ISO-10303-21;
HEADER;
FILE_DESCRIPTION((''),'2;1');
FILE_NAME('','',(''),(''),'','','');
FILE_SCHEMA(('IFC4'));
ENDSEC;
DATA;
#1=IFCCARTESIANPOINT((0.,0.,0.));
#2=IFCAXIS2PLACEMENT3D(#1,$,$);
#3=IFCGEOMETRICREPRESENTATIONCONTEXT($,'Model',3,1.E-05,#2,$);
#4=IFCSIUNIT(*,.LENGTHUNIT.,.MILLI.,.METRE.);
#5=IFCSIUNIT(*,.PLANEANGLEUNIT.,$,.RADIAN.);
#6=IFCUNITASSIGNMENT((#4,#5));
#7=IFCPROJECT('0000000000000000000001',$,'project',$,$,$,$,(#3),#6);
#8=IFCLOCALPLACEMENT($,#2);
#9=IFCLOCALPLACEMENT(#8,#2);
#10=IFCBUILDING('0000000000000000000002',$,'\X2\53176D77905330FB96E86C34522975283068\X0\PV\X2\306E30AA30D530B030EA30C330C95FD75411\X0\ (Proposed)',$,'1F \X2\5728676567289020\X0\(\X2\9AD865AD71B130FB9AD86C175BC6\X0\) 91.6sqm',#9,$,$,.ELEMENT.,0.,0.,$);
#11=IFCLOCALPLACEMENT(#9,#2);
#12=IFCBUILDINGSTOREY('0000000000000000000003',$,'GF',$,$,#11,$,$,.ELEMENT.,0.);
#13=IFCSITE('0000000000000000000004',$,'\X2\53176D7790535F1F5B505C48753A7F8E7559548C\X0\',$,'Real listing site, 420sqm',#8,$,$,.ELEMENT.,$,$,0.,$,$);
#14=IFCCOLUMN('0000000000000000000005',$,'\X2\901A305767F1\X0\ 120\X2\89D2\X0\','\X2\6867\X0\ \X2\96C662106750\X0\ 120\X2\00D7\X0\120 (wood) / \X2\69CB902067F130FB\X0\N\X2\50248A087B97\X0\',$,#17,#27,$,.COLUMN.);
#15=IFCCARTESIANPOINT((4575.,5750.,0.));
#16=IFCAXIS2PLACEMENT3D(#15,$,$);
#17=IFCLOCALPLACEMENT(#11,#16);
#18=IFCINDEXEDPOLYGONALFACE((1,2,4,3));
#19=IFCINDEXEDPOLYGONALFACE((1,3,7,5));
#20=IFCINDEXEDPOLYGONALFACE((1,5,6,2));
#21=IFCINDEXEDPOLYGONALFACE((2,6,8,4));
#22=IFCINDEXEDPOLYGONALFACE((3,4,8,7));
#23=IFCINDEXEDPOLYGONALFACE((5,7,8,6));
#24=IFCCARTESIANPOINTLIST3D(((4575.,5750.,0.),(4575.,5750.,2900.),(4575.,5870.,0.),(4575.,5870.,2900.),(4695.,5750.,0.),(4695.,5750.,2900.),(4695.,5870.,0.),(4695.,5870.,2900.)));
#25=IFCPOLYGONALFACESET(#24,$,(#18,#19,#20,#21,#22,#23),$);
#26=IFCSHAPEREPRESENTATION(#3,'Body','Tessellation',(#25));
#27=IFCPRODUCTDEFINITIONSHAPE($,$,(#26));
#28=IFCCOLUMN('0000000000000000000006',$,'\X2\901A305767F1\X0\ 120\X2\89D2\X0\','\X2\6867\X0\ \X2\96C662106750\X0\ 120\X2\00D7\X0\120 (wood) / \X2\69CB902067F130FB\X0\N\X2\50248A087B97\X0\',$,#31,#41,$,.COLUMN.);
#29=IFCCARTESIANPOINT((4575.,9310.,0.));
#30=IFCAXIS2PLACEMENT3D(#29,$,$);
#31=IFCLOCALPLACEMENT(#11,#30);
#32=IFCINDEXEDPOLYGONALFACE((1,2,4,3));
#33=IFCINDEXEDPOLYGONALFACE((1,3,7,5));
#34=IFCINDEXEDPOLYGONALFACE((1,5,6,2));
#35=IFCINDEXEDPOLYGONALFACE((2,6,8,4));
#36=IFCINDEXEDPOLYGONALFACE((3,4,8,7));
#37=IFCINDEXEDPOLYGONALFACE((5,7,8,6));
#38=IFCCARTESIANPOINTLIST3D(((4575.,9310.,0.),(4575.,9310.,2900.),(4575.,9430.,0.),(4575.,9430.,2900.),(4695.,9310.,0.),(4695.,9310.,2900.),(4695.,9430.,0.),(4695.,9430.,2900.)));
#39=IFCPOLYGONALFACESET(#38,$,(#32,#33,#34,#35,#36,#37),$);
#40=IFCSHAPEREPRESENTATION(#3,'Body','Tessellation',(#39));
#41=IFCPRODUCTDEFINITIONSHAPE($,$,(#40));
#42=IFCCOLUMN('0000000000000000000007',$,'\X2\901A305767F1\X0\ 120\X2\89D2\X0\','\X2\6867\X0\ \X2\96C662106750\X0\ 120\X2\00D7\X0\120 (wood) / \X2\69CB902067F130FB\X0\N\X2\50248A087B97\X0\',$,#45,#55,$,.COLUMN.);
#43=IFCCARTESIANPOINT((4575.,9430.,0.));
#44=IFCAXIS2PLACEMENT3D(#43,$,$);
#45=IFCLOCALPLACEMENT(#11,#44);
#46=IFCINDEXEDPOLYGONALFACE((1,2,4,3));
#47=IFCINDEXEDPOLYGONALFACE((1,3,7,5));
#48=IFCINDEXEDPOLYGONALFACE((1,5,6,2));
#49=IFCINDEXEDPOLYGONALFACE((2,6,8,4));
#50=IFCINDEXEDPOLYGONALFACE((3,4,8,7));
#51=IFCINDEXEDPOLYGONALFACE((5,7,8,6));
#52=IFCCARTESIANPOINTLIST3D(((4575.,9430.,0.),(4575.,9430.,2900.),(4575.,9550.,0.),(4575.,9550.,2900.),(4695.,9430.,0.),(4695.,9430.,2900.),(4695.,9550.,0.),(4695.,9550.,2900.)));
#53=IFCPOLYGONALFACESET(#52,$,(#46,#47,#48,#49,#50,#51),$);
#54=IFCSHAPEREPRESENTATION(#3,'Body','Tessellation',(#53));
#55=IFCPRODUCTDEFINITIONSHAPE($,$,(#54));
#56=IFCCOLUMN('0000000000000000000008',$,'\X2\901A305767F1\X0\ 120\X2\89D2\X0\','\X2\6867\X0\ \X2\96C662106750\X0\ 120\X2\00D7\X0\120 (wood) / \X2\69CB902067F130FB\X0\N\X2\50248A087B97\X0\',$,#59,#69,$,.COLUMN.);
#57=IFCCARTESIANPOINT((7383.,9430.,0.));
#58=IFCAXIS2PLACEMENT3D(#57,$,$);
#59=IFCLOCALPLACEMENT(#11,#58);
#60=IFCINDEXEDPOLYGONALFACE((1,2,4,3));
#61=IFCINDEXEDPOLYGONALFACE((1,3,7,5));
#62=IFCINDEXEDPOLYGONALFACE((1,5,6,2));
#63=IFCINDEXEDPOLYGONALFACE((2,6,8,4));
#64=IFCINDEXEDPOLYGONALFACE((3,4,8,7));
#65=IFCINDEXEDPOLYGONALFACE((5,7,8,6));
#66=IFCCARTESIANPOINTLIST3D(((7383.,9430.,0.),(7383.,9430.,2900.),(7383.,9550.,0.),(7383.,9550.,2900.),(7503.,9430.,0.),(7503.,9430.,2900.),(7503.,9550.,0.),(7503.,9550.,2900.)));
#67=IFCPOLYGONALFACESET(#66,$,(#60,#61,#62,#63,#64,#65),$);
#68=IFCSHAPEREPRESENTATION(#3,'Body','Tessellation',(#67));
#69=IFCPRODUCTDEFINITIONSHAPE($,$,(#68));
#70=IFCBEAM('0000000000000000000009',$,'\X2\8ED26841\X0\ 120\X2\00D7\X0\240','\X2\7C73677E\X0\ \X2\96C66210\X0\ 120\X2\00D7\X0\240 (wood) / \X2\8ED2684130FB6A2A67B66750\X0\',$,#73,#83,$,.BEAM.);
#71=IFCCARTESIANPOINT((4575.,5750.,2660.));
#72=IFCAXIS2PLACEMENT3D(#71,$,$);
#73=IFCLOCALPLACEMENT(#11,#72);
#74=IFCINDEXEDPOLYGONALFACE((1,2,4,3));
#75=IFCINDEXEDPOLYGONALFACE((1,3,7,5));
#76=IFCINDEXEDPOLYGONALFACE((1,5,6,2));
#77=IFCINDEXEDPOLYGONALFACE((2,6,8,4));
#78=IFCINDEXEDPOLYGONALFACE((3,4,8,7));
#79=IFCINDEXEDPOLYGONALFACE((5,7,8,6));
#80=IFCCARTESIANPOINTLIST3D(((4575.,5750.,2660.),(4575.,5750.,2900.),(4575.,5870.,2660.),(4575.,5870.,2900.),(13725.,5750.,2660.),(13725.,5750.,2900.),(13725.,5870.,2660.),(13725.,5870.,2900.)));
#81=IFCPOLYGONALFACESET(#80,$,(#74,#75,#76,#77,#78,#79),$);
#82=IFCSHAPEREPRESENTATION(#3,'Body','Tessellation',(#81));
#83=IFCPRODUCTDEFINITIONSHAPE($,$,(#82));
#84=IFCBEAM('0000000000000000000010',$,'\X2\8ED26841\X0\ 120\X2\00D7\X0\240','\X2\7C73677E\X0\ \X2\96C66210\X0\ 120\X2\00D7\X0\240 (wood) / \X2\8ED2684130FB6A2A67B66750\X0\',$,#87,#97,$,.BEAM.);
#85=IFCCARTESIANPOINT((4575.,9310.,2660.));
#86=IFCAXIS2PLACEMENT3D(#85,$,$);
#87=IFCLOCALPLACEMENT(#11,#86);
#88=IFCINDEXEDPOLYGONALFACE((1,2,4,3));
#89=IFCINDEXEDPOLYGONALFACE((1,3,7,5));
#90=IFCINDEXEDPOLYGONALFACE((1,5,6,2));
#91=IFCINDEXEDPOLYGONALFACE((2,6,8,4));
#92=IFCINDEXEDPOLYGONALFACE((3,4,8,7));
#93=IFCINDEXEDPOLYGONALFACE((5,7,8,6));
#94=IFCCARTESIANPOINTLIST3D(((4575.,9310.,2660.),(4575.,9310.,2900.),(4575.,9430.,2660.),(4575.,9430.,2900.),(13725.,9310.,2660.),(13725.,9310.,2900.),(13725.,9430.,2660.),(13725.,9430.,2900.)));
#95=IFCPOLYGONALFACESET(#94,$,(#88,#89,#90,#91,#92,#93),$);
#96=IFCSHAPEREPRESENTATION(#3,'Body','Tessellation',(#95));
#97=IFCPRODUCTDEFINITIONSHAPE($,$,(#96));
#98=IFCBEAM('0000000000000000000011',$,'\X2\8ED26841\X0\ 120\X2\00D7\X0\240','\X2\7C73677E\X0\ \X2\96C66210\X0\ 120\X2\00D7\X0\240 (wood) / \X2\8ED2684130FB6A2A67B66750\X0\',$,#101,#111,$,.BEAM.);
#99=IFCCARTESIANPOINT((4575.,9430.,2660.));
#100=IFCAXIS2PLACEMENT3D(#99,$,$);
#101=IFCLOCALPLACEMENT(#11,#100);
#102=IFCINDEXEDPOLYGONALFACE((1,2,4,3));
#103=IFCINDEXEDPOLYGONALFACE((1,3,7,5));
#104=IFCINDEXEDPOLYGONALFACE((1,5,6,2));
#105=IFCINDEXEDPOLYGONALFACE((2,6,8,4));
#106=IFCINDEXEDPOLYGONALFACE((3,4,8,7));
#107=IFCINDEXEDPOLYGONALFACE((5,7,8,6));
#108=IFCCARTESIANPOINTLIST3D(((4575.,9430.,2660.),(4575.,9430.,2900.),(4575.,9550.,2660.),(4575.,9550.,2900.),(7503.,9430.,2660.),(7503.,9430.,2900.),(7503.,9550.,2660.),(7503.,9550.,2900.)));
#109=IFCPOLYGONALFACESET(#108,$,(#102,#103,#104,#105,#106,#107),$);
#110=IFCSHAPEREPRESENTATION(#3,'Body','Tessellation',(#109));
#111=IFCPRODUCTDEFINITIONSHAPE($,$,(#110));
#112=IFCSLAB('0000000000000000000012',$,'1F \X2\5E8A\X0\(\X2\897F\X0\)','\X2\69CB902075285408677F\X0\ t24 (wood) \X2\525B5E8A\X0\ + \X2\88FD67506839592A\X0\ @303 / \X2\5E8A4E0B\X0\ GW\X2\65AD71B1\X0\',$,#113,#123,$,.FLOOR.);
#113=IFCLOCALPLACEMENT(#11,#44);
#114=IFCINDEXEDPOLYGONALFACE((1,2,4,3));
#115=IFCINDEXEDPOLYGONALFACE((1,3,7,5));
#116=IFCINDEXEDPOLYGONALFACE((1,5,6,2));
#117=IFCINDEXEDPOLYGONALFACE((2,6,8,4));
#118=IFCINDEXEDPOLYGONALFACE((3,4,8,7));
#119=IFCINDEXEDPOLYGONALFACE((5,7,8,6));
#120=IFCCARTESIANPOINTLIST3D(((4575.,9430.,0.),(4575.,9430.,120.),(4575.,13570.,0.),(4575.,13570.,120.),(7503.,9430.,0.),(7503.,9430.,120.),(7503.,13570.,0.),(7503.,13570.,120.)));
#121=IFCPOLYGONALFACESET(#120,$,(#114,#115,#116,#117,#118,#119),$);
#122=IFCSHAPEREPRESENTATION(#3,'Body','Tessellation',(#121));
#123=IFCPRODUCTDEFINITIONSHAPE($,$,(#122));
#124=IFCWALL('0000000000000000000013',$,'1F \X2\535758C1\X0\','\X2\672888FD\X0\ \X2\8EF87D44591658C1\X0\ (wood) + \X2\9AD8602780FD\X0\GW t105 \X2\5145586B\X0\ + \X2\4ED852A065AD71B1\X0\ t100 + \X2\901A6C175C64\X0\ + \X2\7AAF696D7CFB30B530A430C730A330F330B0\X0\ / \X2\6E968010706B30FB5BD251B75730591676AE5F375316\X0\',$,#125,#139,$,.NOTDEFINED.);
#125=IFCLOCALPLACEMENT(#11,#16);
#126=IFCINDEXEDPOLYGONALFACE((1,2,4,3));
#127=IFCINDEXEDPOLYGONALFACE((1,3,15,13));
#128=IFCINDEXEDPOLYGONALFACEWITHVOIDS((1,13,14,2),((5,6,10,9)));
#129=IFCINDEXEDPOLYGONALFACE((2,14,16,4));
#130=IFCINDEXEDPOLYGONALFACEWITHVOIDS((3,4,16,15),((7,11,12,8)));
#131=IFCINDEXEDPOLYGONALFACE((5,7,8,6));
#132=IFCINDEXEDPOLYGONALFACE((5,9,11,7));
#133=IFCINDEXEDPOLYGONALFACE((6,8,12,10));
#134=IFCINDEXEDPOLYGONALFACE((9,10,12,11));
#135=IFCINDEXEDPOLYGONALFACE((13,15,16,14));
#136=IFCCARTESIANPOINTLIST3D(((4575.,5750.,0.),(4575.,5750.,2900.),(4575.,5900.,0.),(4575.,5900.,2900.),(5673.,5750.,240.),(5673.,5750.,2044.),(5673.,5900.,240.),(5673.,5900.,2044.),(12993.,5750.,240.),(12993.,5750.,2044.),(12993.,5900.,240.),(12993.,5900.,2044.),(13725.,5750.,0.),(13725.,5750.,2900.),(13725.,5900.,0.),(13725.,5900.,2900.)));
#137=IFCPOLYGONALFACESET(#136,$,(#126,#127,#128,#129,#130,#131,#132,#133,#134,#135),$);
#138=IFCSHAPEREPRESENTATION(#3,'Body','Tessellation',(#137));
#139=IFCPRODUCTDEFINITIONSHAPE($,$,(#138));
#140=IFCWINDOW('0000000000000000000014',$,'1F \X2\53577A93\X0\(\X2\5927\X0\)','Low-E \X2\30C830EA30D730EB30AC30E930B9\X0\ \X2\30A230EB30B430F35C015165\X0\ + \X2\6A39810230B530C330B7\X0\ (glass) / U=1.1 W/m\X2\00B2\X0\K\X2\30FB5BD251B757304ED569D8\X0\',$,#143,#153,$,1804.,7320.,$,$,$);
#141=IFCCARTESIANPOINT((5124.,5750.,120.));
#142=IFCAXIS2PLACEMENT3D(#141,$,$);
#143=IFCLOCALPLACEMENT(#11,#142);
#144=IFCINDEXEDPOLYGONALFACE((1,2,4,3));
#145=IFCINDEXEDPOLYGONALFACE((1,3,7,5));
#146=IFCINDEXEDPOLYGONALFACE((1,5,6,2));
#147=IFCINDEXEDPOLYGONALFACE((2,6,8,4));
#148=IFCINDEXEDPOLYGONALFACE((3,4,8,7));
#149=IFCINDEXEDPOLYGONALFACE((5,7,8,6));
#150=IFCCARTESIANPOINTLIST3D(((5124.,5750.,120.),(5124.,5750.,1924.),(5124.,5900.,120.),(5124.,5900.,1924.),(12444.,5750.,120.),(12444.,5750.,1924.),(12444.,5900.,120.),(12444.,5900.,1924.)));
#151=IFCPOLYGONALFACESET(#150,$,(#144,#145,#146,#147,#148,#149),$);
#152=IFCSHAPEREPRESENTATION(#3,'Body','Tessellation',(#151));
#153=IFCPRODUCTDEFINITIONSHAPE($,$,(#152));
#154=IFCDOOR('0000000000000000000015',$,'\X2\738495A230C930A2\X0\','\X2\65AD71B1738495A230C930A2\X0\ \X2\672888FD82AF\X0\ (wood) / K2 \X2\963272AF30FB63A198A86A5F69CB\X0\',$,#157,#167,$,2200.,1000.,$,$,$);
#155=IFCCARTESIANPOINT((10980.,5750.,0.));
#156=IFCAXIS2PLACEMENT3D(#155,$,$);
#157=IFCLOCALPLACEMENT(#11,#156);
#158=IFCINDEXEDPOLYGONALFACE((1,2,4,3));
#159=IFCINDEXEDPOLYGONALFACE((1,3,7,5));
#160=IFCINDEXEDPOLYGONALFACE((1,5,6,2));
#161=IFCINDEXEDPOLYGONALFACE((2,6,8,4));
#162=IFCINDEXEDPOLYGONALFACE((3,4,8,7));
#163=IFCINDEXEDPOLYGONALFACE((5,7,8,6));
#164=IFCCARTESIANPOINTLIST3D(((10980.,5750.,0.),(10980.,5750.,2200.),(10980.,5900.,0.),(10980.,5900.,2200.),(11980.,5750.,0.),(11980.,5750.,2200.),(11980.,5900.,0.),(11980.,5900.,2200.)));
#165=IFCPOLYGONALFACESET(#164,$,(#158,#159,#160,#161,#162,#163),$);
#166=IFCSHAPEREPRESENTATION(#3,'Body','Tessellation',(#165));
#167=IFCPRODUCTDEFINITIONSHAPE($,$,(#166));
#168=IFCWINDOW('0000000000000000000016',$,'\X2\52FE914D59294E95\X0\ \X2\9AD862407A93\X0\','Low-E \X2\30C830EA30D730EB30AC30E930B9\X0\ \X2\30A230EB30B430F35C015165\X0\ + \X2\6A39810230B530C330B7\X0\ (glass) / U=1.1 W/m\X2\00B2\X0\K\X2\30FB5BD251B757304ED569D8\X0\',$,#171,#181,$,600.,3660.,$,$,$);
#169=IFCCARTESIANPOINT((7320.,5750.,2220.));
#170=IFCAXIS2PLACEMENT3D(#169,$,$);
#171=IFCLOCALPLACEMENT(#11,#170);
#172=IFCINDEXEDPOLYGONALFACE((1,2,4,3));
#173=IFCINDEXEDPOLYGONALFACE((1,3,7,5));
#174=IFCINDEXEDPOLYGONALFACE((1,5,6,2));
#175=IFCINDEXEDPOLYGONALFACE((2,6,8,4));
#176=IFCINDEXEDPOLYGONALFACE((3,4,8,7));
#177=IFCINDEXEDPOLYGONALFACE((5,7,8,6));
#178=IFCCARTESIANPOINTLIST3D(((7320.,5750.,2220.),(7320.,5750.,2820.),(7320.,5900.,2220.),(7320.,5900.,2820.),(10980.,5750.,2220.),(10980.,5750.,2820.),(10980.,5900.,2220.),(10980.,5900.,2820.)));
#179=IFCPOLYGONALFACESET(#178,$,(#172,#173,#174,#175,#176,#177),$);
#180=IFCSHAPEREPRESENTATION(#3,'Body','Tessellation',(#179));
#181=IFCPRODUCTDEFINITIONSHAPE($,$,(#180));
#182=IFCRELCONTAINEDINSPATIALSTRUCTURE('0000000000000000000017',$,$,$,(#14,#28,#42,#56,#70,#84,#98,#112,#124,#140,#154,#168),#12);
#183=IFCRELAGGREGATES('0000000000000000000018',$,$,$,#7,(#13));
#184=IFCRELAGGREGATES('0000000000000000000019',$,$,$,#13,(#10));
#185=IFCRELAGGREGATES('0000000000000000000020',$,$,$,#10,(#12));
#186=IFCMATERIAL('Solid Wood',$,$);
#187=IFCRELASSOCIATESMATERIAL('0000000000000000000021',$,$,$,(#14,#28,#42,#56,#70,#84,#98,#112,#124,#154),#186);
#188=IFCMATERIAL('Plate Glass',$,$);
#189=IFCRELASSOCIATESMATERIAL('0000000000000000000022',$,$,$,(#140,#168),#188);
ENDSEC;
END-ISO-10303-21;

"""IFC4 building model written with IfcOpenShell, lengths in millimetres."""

from ifc_helpers import new_model, si_unit, frame, frame_2d, origin, place, context, project, spatial, rectangle, extrude, material, element, fill, save


model = new_model("IFC4")

# Units and contexts
model_context = context("Model", 3, precision=1e-05, world=origin())
ifc_project = project(units=[si_unit("LENGTHUNIT", "METRE", prefix="MILLI"), si_unit("PLANEANGLEUNIT", "RADIAN")], contexts=[model_context])

# Site, building, storey
site_placement = place(None, origin())
site = spatial("IfcSite", under=ifc_project, at=site_placement, Name="北海道弟子屈町美留和", ObjectType="Real listing site, 420sqm", CompositionType="ELEMENT", RefElevation=0.0)
building_placement = place(site_placement, origin())
building = spatial("IfcBuilding", under=site, at=building_placement, Name="北海道・雨水利用とPVのオフグリッド志向 (Proposed)", ObjectType="1F 在来木造(高断熱・高気密) 91.6sqm", CompositionType="ELEMENT", ElevationOfRefHeight=0.0, ElevationOfTerrain=0.0)
storey_placement = place(building_placement, origin())
storey = spatial("IfcBuildingStorey", under=building, at=storey_placement, Name="GF", CompositionType="ELEMENT", Elevation=0.0)

# Columns
ifc_material_1 = material(Name="Solid Wood")
column_1_placement = place(storey_placement, frame((4575.0, 5750.0, 0.0)))
element("IfcColumn", 1, at=column_1_placement, inside=storey, material=ifc_material_1, Name="通し柱 120角", Description="桧 集成材 120×120 (wood) / 構造柱・N値計算", PredefinedType="COLUMN", context=model_context, shape_type="SweptSolid", body=[
    extrude(rectangle(XDim=120.0, YDim=120.0, at=frame_2d((60.0, 60.0))), frame((4575.0, 5750.0, 0.0)), (0.0, 0.0, 1.0), 2900.0),
])
column_2_placement = place(storey_placement, frame((4575.0, 9310.0, 0.0)))
element("IfcColumn", 2, at=column_2_placement, inside=storey, material=ifc_material_1, Name="通し柱 120角", Description="桧 集成材 120×120 (wood) / 構造柱・N値計算", PredefinedType="COLUMN", context=model_context, shape_type="SweptSolid", body=[
    extrude(rectangle(XDim=120.0, YDim=120.0, at=frame_2d((60.0, 60.0))), frame((4575.0, 9310.0, 0.0)), (0.0, 0.0, 1.0), 2900.0),
])
column_3_placement = place(storey_placement, frame((4575.0, 9430.0, 0.0)))
element("IfcColumn", 3, at=column_3_placement, inside=storey, material=ifc_material_1, Name="通し柱 120角", Description="桧 集成材 120×120 (wood) / 構造柱・N値計算", PredefinedType="COLUMN", context=model_context, shape_type="SweptSolid", body=[
    extrude(rectangle(XDim=120.0, YDim=120.0, at=frame_2d((60.0, 60.0))), frame((4575.0, 9430.0, 0.0)), (0.0, 0.0, 1.0), 2900.0),
])
column_4_placement = place(storey_placement, frame((7383.0, 9430.0, 0.0)))
element("IfcColumn", 4, at=column_4_placement, inside=storey, material=ifc_material_1, Name="通し柱 120角", Description="桧 集成材 120×120 (wood) / 構造柱・N値計算", PredefinedType="COLUMN", context=model_context, shape_type="SweptSolid", body=[
    extrude(rectangle(XDim=120.0, YDim=120.0, at=frame_2d((60.0, 60.0))), frame((7383.0, 9430.0, 0.0)), (0.0, 0.0, 1.0), 2900.0),
])

# Beams
beam_1_placement = place(storey_placement, frame((4575.0, 5750.0, 2660.0)))
element("IfcBeam", 5, at=beam_1_placement, inside=storey, material=ifc_material_1, Name="軒桁 120×240", Description="米松 集成 120×240 (wood) / 軒桁・横架材", PredefinedType="BEAM", context=model_context, shape_type="SweptSolid", body=[
    extrude(rectangle(XDim=9150.0, YDim=120.0, at=frame_2d((4575.0, 60.0))), frame((4575.0, 5750.0, 2660.0)), (0.0, 0.0, 1.0), 240.0),
])
beam_2_placement = place(storey_placement, frame((4575.0, 9310.0, 2660.0)))
element("IfcBeam", 6, at=beam_2_placement, inside=storey, material=ifc_material_1, Name="軒桁 120×240", Description="米松 集成 120×240 (wood) / 軒桁・横架材", PredefinedType="BEAM", context=model_context, shape_type="SweptSolid", body=[
    extrude(rectangle(XDim=9150.0, YDim=120.0, at=frame_2d((4575.0, 60.0))), frame((4575.0, 9310.0, 2660.0)), (0.0, 0.0, 1.0), 240.0),
])
beam_3_placement = place(storey_placement, frame((4575.0, 9430.0, 2660.0)))
element("IfcBeam", 7, at=beam_3_placement, inside=storey, material=ifc_material_1, Name="軒桁 120×240", Description="米松 集成 120×240 (wood) / 軒桁・横架材", PredefinedType="BEAM", context=model_context, shape_type="SweptSolid", body=[
    extrude(rectangle(XDim=2928.0, YDim=120.0, at=frame_2d((1464.0, 60.0))), frame((4575.0, 9430.0, 2660.0)), (0.0, 0.0, 1.0), 240.0),
])

# Slab
slab_1_placement = place(storey_placement, frame((4575.0, 9430.0, 0.0)))
element("IfcSlab", 8, at=slab_1_placement, inside=storey, material=ifc_material_1, Name="1F 床(西)", Description="構造用合板 t24 (wood) 剛床 + 製材根太 @303 / 床下 GW断熱", PredefinedType="FLOOR", context=model_context, shape_type="SweptSolid", body=[
    extrude(rectangle(XDim=2928.0, YDim=4140.0, at=frame_2d((1464.0, 2070.0))), frame((4575.0, 9430.0, 0.0)), (0.0, 0.0, 1.0), 120.0),
])

# Wall, openings, windows, door
wall_1_placement = place(storey_placement, frame((4575.0, 5750.0, 0.0)))
wall_1 = element("IfcWall", 9, at=wall_1_placement, inside=storey, material=ifc_material_1, Name="1F 南壁", Description="木製 軸組外壁 (wood) + 高性能GW t105 充填 + 付加断熱 t100 + 通気層 + 窯業系サイディング / 準耐火・寒冷地外皮強化", PredefinedType="NOTDEFINED", context=model_context, shape_type="SweptSolid", body=[
    extrude(rectangle(XDim=9150.0, YDim=150.0, at=frame_2d((4575.0, 75.0))), frame((4575.0, 5750.0, 0.0)), (0.0, 0.0, 1.0), 2900.0),
])
opening_1_placement = place(storey_placement, frame((5124.0, 5750.0, 120.0)))
opening_1 = element("IfcOpeningElement", 10, at=opening_1_placement, cuts=wall_1, PredefinedType="NOTDEFINED", context=model_context, shape_type="SweptSolid", body=[
    extrude(rectangle(XDim=7320.0, YDim=150.0, at=frame_2d((3660.0, 75.0))), frame((5124.0, 5750.0, 120.0)), (0.0, 0.0, 1.0), 1804.0),
])
opening_2_placement = place(storey_placement, frame((10980.0, 5750.0, 0.0)))
opening_2 = element("IfcOpeningElement", 11, at=opening_2_placement, cuts=wall_1, PredefinedType="NOTDEFINED", context=model_context, shape_type="SweptSolid", body=[
    extrude(rectangle(XDim=1000.0, YDim=150.0, at=frame_2d((500.0, 75.0))), frame((10980.0, 5750.0, 0.0)), (0.0, 0.0, 1.0), 2200.0),
])
opening_3_placement = place(storey_placement, frame((7320.0, 5750.0, 2220.0)))
opening_3 = element("IfcOpeningElement", 12, at=opening_3_placement, cuts=wall_1, PredefinedType="NOTDEFINED", context=model_context, shape_type="SweptSolid", body=[
    extrude(rectangle(XDim=3660.0, YDim=150.0, at=frame_2d((1830.0, 75.0))), frame((7320.0, 5750.0, 2220.0)), (0.0, 0.0, 1.0), 600.0),
])
ifc_material_2 = material(Name="Plate Glass")
window_1_placement = place(storey_placement, frame((5124.0, 5750.0, 120.0)))
window_1 = element("IfcWindow", 13, at=window_1_placement, inside=storey, material=ifc_material_2, Name="1F 南窓(大)", Description="Low-E トリプルガラス アルゴン封入 + 樹脂サッシ (glass) / U=1.1 W/m²K・寒冷地仕様", OverallHeight=1804.0, OverallWidth=7320.0, context=model_context, shape_type="SweptSolid", body=[
    extrude(rectangle(XDim=7320.0, YDim=150.0, at=frame_2d((3660.0, 75.0))), frame((5124.0, 5750.0, 120.0)), (0.0, 0.0, 1.0), 1804.0),
])
fill(opening_1, window_1)
door_placement = place(storey_placement, frame((10980.0, 5750.0, 0.0)))
door = element("IfcDoor", 14, at=door_placement, inside=storey, material=ifc_material_1, Name="玄関ドア", Description="断熱玄関ドア 木製芯 (wood) / K2 防犯・採風機構", OverallHeight=2200.0, OverallWidth=1000.0, context=model_context, shape_type="SweptSolid", body=[
    extrude(rectangle(XDim=1000.0, YDim=150.0, at=frame_2d((500.0, 75.0))), frame((10980.0, 5750.0, 0.0)), (0.0, 0.0, 1.0), 2200.0),
])
fill(opening_2, door)
window_2_placement = place(storey_placement, frame((7320.0, 5750.0, 2220.0)))
window_2 = element("IfcWindow", 15, at=window_2_placement, inside=storey, material=ifc_material_2, Name="勾配天井 高所窓", Description="Low-E トリプルガラス アルゴン封入 + 樹脂サッシ (glass) / U=1.1 W/m²K・寒冷地仕様", OverallHeight=600.0, OverallWidth=3660.0, context=model_context, shape_type="SweptSolid", body=[
    extrude(rectangle(XDim=3660.0, YDim=150.0, at=frame_2d((1830.0, 75.0))), frame((7320.0, 5750.0, 2220.0)), (0.0, 0.0, 1.0), 600.0),
])
fill(opening_3, window_2)

save(model, "model.ifc")
